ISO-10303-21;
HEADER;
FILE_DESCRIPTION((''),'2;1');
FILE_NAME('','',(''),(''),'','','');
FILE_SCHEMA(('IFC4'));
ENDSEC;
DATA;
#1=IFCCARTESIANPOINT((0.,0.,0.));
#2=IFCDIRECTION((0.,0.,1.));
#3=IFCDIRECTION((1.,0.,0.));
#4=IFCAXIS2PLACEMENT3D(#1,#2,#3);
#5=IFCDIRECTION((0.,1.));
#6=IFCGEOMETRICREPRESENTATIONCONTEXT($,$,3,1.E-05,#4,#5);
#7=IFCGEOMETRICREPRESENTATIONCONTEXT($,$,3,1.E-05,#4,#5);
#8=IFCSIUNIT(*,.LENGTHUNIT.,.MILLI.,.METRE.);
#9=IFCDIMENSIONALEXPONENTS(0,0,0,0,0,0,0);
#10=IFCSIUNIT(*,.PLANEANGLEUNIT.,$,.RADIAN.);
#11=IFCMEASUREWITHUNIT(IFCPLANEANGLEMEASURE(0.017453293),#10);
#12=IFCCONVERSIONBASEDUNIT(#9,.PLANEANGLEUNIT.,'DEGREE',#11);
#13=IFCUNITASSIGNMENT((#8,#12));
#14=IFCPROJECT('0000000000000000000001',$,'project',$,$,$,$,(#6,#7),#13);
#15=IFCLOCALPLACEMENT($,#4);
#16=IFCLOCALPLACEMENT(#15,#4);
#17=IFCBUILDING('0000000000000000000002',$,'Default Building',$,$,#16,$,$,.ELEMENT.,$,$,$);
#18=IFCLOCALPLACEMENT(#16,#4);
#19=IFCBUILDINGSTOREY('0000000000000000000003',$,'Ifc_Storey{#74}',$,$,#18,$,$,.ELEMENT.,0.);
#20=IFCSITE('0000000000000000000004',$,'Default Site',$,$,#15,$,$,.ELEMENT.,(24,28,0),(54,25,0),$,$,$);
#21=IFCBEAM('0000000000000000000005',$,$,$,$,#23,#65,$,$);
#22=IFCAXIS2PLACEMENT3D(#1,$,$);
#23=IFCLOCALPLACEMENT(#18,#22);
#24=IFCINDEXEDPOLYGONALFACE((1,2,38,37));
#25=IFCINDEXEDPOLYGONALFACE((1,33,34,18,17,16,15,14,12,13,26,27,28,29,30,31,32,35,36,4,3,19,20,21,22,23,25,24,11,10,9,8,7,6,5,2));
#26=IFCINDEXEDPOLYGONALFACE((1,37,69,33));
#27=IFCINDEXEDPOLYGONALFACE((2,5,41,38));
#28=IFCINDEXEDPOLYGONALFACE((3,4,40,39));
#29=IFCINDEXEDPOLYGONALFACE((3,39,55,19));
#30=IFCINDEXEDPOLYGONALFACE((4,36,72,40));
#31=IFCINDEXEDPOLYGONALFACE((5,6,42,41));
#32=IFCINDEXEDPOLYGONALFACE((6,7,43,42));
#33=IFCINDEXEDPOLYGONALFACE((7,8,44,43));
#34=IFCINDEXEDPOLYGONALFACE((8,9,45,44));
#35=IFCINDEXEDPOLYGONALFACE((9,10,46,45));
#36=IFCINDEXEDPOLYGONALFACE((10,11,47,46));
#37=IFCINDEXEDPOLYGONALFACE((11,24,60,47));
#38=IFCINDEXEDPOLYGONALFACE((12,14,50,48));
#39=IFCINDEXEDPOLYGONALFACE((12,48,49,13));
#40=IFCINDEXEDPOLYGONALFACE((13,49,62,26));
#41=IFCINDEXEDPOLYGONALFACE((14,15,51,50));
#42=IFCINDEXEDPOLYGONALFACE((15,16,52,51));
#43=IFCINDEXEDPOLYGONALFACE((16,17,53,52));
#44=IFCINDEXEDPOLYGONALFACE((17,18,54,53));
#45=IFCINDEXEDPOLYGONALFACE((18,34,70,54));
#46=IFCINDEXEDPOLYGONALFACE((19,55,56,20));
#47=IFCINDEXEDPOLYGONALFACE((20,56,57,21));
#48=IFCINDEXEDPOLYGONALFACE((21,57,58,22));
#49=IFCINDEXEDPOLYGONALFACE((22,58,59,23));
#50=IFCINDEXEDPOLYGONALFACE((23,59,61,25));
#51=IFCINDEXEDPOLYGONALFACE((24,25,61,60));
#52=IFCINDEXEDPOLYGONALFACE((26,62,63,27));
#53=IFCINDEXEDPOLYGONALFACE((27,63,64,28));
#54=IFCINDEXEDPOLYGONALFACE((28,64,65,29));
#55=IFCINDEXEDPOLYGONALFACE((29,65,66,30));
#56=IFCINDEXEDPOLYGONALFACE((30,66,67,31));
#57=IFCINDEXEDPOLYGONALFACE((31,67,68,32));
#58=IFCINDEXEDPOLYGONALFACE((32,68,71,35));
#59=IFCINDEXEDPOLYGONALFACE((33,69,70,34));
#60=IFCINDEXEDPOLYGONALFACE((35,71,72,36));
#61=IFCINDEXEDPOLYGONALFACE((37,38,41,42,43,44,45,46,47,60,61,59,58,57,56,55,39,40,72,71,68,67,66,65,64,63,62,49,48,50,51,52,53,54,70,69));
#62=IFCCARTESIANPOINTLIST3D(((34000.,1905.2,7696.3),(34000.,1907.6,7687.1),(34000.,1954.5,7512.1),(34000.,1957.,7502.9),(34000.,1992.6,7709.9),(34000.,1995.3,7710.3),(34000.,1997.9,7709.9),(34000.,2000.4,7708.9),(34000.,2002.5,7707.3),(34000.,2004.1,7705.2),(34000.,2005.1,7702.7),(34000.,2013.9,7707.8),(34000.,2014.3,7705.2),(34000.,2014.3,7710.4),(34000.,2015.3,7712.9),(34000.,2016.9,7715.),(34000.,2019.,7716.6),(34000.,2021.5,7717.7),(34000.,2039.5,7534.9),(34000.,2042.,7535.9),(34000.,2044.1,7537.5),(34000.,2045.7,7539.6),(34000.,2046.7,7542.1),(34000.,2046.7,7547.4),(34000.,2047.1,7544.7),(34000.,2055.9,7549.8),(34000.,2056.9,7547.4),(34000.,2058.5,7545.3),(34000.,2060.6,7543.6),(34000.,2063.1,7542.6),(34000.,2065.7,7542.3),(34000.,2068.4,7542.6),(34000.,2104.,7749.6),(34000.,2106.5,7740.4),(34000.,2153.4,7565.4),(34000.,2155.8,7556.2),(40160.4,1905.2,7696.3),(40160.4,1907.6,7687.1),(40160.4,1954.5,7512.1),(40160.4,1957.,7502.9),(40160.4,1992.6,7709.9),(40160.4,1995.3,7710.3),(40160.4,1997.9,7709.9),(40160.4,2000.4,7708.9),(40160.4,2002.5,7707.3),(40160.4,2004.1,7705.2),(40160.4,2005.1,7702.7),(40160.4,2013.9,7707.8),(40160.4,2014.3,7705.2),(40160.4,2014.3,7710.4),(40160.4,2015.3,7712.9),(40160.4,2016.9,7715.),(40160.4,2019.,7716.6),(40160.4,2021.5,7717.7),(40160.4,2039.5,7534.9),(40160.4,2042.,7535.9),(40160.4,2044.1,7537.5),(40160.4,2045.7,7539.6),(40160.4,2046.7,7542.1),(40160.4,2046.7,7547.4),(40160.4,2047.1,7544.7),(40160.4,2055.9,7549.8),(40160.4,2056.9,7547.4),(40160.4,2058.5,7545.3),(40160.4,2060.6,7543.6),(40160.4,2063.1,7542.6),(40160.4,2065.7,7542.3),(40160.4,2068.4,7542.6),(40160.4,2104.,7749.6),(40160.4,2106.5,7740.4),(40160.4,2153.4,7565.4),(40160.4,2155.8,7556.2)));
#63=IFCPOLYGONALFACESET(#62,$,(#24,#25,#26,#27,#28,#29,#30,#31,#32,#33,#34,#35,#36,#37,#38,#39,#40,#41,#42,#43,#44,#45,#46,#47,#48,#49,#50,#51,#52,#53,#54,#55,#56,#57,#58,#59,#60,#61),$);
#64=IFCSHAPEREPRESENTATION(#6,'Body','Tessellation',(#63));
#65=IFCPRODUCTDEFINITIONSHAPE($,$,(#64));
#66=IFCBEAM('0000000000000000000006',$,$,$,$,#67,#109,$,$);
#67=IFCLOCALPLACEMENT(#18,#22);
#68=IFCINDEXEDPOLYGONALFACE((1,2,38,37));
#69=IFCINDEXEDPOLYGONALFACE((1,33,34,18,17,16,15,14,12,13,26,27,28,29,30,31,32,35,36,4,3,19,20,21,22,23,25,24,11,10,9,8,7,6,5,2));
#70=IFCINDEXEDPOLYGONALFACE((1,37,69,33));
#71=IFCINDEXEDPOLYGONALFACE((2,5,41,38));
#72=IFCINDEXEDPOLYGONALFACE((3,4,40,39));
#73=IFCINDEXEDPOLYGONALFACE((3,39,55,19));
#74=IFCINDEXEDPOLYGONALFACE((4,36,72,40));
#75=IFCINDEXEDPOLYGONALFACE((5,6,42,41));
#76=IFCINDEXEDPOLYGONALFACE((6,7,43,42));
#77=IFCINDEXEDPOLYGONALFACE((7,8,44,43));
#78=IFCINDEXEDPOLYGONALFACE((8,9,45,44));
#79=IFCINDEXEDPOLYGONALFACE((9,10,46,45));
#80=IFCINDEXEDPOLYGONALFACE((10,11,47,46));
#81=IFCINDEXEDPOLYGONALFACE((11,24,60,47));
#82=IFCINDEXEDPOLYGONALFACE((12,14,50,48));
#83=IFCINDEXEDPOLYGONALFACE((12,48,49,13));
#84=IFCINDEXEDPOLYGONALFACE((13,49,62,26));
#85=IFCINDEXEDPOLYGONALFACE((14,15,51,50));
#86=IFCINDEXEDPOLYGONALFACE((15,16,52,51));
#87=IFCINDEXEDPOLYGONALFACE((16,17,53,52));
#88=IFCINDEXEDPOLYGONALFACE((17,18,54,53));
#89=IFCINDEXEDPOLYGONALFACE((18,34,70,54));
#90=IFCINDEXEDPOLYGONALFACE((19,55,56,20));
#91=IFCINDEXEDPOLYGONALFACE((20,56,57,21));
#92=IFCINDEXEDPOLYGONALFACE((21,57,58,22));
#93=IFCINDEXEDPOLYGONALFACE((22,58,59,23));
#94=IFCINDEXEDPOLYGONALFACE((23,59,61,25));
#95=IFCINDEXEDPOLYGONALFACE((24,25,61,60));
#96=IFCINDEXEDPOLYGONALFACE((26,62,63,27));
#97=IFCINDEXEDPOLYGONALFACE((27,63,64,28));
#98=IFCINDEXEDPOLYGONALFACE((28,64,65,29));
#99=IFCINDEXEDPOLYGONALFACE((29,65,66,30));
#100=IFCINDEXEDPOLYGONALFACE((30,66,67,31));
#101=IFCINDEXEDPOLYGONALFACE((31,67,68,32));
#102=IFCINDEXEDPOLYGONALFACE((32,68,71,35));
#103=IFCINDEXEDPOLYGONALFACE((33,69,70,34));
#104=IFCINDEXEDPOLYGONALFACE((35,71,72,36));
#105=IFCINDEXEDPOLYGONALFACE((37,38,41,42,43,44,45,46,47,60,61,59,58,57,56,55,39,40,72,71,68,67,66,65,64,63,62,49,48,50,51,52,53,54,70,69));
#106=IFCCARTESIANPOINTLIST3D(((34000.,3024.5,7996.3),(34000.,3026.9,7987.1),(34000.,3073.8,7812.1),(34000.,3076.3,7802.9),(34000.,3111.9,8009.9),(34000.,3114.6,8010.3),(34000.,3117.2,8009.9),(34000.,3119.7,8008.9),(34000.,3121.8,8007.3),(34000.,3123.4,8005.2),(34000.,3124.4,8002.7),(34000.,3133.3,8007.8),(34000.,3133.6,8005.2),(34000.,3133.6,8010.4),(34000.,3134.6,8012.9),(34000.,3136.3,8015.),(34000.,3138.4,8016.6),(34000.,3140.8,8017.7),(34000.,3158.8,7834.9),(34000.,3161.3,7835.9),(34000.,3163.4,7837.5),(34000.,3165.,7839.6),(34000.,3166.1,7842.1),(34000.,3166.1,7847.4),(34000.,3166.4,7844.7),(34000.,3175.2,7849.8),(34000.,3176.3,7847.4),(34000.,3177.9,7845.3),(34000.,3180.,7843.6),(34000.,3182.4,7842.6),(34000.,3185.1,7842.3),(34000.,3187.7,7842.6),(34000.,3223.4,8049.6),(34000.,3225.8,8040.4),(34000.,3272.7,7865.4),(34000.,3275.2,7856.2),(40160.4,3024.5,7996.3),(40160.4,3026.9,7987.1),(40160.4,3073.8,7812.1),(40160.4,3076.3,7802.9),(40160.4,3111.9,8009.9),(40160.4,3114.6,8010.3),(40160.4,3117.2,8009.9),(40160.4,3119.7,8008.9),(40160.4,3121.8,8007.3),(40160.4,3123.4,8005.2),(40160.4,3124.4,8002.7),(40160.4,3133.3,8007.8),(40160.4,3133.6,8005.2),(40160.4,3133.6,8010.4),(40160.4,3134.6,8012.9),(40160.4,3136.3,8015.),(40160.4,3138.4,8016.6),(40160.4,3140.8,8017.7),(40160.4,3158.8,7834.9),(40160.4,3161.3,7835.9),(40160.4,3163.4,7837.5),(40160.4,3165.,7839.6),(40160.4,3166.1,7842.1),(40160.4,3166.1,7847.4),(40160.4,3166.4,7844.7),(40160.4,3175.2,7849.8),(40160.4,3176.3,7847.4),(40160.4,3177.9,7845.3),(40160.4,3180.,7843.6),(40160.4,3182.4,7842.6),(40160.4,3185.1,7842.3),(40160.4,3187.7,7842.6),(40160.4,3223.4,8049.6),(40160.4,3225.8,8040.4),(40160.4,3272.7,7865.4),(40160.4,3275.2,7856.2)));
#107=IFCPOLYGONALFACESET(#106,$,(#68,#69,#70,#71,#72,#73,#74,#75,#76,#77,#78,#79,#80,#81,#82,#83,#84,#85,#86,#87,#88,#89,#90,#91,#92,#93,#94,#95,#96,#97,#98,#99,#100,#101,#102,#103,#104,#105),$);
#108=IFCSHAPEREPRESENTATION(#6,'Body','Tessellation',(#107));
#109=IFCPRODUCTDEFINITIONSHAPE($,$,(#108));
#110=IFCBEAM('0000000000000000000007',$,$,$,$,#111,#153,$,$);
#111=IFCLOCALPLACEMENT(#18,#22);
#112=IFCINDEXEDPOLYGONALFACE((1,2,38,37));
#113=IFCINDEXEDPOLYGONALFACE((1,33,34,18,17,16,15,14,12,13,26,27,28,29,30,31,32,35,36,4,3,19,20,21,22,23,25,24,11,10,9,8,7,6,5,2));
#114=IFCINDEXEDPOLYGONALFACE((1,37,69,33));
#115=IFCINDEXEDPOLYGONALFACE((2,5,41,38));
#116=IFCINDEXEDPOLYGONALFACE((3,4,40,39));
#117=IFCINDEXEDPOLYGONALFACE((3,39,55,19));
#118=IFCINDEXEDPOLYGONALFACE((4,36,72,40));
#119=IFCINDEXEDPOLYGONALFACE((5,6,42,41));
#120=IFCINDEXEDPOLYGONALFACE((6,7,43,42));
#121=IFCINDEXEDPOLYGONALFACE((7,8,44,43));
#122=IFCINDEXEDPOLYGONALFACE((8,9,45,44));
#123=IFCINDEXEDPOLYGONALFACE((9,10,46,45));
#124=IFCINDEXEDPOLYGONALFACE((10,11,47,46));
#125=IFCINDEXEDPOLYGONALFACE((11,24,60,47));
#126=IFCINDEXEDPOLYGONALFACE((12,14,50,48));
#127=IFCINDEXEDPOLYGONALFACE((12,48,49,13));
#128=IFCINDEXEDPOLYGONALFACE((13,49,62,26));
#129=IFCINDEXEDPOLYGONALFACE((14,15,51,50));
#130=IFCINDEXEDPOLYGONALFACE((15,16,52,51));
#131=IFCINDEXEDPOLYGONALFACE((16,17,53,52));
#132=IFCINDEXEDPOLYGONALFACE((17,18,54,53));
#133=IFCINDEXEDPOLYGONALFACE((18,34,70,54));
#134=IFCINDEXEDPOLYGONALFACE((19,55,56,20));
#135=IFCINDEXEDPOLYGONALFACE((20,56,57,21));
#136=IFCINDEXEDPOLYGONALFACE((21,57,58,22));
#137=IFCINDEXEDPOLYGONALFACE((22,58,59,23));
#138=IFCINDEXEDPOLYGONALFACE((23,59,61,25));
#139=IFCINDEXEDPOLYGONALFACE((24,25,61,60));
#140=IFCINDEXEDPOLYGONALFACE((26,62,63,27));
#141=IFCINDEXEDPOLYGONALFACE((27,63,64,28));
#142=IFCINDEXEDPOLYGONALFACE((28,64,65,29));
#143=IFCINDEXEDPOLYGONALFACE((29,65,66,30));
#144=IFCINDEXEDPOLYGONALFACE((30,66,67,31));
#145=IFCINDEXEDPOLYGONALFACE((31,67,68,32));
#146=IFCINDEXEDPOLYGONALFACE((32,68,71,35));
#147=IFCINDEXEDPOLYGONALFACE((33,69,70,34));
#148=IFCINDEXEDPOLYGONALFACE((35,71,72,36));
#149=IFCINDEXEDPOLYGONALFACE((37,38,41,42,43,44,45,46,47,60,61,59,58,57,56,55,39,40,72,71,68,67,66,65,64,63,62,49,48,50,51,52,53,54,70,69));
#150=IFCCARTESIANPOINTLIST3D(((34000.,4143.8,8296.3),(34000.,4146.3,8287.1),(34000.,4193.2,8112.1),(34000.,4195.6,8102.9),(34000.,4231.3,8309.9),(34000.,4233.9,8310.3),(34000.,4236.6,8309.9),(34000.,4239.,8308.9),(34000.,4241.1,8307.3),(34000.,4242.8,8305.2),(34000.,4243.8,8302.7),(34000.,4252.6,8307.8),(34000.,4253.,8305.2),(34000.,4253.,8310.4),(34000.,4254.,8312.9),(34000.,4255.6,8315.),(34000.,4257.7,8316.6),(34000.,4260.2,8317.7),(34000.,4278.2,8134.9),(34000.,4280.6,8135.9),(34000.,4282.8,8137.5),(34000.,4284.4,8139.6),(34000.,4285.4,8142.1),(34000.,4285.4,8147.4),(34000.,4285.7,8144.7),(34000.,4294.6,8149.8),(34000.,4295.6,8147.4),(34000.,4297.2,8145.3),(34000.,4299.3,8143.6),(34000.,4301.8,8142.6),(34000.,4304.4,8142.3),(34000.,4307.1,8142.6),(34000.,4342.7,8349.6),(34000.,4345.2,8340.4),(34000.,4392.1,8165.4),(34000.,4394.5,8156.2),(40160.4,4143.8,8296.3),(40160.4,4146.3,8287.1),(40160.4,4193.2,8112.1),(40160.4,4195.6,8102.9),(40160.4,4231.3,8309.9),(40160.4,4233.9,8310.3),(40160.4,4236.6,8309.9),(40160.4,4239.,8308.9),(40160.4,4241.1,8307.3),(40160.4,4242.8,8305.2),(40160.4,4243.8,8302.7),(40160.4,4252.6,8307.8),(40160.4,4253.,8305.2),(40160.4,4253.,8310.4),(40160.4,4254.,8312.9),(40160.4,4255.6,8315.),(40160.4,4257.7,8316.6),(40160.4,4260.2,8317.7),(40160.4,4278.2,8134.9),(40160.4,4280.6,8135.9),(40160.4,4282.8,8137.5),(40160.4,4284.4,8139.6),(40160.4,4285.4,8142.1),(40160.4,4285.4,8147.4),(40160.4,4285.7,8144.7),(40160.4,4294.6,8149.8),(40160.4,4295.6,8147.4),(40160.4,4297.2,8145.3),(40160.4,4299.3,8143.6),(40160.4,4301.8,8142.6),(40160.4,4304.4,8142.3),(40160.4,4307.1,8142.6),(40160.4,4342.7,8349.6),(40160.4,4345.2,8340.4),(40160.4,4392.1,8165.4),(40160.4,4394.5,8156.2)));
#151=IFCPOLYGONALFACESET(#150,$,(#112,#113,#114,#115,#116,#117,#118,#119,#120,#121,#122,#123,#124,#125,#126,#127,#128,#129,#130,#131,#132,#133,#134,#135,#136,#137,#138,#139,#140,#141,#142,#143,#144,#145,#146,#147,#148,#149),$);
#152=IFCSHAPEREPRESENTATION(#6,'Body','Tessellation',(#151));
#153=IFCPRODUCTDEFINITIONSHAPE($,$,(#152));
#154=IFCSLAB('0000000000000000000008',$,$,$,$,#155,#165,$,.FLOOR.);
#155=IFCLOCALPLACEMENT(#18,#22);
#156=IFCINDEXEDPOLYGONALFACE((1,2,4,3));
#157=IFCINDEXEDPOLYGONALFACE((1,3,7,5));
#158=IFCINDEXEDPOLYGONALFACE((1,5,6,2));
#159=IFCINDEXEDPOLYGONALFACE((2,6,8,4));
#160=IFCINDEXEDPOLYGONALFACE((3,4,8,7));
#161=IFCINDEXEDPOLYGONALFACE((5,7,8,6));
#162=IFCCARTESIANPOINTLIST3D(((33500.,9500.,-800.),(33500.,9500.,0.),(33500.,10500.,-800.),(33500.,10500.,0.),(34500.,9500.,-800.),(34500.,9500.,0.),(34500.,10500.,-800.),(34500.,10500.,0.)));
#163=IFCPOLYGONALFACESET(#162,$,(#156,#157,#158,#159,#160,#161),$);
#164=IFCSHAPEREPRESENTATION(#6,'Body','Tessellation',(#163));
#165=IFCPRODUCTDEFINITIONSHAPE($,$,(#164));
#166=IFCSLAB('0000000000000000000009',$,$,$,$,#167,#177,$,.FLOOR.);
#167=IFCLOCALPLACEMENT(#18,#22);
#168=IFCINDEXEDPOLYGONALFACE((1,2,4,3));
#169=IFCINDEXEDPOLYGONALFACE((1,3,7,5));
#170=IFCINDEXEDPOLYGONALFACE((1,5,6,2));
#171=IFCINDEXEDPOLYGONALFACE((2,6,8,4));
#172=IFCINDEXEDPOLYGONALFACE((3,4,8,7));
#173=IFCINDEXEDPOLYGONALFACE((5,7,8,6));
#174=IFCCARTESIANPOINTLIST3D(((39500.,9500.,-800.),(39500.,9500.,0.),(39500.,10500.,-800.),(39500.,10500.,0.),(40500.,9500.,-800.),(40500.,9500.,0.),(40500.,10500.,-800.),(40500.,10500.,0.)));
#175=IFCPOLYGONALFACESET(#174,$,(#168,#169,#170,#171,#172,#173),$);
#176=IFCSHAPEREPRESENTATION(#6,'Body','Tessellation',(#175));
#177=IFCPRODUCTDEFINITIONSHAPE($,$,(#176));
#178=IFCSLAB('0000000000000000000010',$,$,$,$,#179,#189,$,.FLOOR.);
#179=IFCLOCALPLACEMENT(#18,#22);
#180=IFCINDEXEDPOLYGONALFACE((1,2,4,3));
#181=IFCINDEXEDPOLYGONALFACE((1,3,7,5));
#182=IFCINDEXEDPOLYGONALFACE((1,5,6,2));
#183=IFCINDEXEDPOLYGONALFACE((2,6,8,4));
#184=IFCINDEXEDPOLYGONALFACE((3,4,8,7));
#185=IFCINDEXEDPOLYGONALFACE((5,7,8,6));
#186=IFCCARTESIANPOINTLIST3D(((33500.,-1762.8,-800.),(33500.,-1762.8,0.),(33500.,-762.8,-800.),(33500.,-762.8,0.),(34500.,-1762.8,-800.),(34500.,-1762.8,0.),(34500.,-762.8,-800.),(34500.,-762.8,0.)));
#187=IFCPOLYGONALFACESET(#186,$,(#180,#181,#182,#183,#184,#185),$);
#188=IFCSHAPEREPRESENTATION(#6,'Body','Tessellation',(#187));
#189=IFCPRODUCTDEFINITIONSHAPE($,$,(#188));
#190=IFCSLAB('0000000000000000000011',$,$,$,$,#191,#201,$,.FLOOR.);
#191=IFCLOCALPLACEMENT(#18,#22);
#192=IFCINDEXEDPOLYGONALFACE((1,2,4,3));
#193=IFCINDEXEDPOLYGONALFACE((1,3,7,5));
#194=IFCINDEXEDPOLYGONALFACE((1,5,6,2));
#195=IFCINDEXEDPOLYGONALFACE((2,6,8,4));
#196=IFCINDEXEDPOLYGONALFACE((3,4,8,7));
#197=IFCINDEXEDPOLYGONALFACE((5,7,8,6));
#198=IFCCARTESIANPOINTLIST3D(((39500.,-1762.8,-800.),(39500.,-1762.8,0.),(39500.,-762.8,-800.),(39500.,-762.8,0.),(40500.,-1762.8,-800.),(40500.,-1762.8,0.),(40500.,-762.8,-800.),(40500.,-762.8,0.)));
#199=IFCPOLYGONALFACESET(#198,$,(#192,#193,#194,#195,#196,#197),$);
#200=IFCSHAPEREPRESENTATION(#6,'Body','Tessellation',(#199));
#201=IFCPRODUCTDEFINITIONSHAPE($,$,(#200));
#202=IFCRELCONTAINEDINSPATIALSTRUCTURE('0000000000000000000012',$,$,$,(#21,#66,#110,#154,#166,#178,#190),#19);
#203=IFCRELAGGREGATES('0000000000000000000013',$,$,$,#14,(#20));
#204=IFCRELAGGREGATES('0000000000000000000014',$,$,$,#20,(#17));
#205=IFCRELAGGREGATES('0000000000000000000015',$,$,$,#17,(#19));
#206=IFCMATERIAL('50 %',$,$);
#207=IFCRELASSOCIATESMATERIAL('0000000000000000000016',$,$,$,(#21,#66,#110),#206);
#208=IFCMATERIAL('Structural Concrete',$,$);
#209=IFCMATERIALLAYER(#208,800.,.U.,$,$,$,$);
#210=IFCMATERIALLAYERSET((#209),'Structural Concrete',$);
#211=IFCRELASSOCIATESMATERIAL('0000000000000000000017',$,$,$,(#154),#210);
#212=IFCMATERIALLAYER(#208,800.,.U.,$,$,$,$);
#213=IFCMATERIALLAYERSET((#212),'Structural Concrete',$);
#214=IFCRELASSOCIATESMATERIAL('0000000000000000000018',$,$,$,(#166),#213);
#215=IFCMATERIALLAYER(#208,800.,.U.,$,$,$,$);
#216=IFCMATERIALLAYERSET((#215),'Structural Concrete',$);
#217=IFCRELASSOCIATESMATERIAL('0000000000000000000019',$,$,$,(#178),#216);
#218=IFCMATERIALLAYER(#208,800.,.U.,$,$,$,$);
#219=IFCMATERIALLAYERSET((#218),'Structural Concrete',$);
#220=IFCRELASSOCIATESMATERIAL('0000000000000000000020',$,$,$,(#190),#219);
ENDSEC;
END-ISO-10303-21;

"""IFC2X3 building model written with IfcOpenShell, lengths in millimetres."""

from ifc_helpers import new_model, entity, si_unit, converted_unit, direction, frame, origin_with_axes, origin_2d_with_axis, place, context, project, spatial, polyline, i_section, outline, extrude, material, layer, layer_set, layer_usage, element, save


model = new_model("IFC2X3")

# Units and contexts
context_of_model_1 = context(None, 3, precision=1e-05, world=origin_with_axes(), true_north=direction((0.0, 1.0)))
context_of_model_2 = context(None, 3, precision=1e-05, world=origin_with_axes(), true_north=direction((0.0, 1.0)))
ifc_project = project(units=[si_unit("LENGTHUNIT", "METRE", prefix="MILLI"), converted_unit("PLANEANGLEUNIT", "DEGREE", entity("IfcPlaneAngleMeasure", 0.017453293), si_unit("PLANEANGLEUNIT", "RADIAN"), dimensions=[0, 0, 0, 0, 0, 0, 0])], contexts=[context_of_model_1, context_of_model_2])

# Site, building, storey
site_placement = place(None, origin_with_axes())
site = spatial("IfcSite", under=ifc_project, at=site_placement, Name="Default Site", CompositionType="ELEMENT", RefLatitude=(24, 28, 0), RefLongitude=(54, 25, 0))
building_placement = place(site_placement, origin_with_axes())
building = spatial("IfcBuilding", under=site, at=building_placement, Name="Default Building", CompositionType="ELEMENT")
storey_placement = place(building_placement, origin_with_axes())
storey = spatial("IfcBuildingStorey", under=building, at=storey_placement, Name="Ifc_Storey{#74}", CompositionType="ELEMENT", Elevation=0.0)

# Shared definitions
ifc_material_1 = material(Name="50 %")

# Beams
for number, where, z_axis, x_axis in (
    (1, (34000.0, 2030.5, 7626.3), (0.0, -0.258819, 0.965926), (-1.0, 0.0, 0.0)),
    (2, (34000.0, 3149.8, 7926.3), (0.0, -0.258819, 0.965926), (-1.0, 0.0, 0.0)),
    (3, (34000.0, 4269.2, 8226.3), (0.0, -0.258819, 0.965926), (-1.0, 0.0, 0.0)),
):
    element("IfcBeam", number, at=place(storey_placement, frame(where, z_axis=z_axis, x_axis=x_axis)), inside=storey, material=ifc_material_1, context=context_of_model_1, shape_type="SweptSolid", body=[
        extrude(i_section(OverallWidth=205.9, OverallDepth=200.2, WebThickness=9.5, FlangeThickness=9.5, FilletRadius=10.2, at=origin_2d_with_axis()), frame((0.0, 0.0, 0.0), z_axis=(-1.0, 0.0, 0.0), x_axis=(0.0, 1.0, 0.0)), (0.0, 0.0, 1.0), 6160.4),
    ])

# Slabs
ifc_material_2 = material(Name="Structural Concrete")
ifc_layer_1 = layer(ifc_material_2, 800.0, ventilated="UNKNOWN")
ifc_layer_set_1 = layer_set([ifc_layer_1], Name="Structural Concrete")
ifc_layer_usage_1 = layer_usage(ifc_layer_set_1, "AXIS3", "NEGATIVE", 800.0)
slab_1_placement = place(storey_placement, frame((33500.0, 10500.0, -800.0), z_axis=(0.0, 0.0, 1.0), x_axis=(0.0, -1.0, 0.0)))
element("IfcSlab", 4, at=slab_1_placement, inside=storey, material=ifc_layer_usage_1, PredefinedType="FLOOR", context=context_of_model_1, shape_type="SweptSolid", body=[
    extrude(outline(polyline([(0.0, 0.0), (1000.0, 0.0), (1000.0, 1000.0), (0.0, 1000.0), (0.0, 0.0)])), origin_with_axes(), (0.0, 0.0, 1.0), 800.0),
])
ifc_layer_2 = layer(ifc_material_2, 800.0, ventilated="UNKNOWN")
ifc_layer_set_2 = layer_set([ifc_layer_2], Name="Structural Concrete")
ifc_layer_usage_2 = layer_usage(ifc_layer_set_2, "AXIS3", "NEGATIVE", 800.0)
slab_2_placement = place(storey_placement, frame((39500.0, 10500.0, -800.0), z_axis=(0.0, 0.0, 1.0), x_axis=(0.0, -1.0, 0.0)))
element("IfcSlab", 5, at=slab_2_placement, inside=storey, material=ifc_layer_usage_2, PredefinedType="FLOOR", context=context_of_model_1, shape_type="SweptSolid", body=[
    extrude(outline(polyline([(0.0, 0.0), (1000.0, 0.0), (1000.0, 1000.0), (0.0, 1000.0), (0.0, 0.0)])), origin_with_axes(), (0.0, 0.0, 1.0), 800.0),
])
ifc_layer_3 = layer(ifc_material_2, 800.0, ventilated="UNKNOWN")
ifc_layer_set_3 = layer_set([ifc_layer_3], Name="Structural Concrete")
ifc_layer_usage_3 = layer_usage(ifc_layer_set_3, "AXIS3", "NEGATIVE", 800.0)
slab_3_placement = place(storey_placement, frame((33500.0, -1762.8, -800.0), z_axis=(0.0, 0.0, 1.0), x_axis=(0.0, 1.0, 0.0)))
element("IfcSlab", 6, at=slab_3_placement, inside=storey, material=ifc_layer_usage_3, PredefinedType="FLOOR", context=context_of_model_1, shape_type="SweptSolid", body=[
    extrude(outline(polyline([(0.0, 0.0), (1000.0, 0.0), (1000.0, -1000.0), (0.0, -1000.0), (0.0, 0.0)])), origin_with_axes(), (0.0, 0.0, 1.0), 800.0),
])
ifc_layer_4 = layer(ifc_material_2, 800.0, ventilated="UNKNOWN")
ifc_layer_set_4 = layer_set([ifc_layer_4], Name="Structural Concrete")
ifc_layer_usage_4 = layer_usage(ifc_layer_set_4, "AXIS3", "NEGATIVE", 800.0)
slab_4_placement = place(storey_placement, frame((39500.0, -1762.8, -800.0), z_axis=(0.0, 0.0, 1.0), x_axis=(0.0, 1.0, 0.0)))
element("IfcSlab", 7, at=slab_4_placement, inside=storey, material=ifc_layer_usage_4, PredefinedType="FLOOR", context=context_of_model_1, shape_type="SweptSolid", body=[
    extrude(outline(polyline([(0.0, 0.0), (1000.0, 0.0), (1000.0, -1000.0), (0.0, -1000.0), (0.0, 0.0)])), origin_with_axes(), (0.0, 0.0, 1.0), 800.0),
])

save(model, "model.ifc")
